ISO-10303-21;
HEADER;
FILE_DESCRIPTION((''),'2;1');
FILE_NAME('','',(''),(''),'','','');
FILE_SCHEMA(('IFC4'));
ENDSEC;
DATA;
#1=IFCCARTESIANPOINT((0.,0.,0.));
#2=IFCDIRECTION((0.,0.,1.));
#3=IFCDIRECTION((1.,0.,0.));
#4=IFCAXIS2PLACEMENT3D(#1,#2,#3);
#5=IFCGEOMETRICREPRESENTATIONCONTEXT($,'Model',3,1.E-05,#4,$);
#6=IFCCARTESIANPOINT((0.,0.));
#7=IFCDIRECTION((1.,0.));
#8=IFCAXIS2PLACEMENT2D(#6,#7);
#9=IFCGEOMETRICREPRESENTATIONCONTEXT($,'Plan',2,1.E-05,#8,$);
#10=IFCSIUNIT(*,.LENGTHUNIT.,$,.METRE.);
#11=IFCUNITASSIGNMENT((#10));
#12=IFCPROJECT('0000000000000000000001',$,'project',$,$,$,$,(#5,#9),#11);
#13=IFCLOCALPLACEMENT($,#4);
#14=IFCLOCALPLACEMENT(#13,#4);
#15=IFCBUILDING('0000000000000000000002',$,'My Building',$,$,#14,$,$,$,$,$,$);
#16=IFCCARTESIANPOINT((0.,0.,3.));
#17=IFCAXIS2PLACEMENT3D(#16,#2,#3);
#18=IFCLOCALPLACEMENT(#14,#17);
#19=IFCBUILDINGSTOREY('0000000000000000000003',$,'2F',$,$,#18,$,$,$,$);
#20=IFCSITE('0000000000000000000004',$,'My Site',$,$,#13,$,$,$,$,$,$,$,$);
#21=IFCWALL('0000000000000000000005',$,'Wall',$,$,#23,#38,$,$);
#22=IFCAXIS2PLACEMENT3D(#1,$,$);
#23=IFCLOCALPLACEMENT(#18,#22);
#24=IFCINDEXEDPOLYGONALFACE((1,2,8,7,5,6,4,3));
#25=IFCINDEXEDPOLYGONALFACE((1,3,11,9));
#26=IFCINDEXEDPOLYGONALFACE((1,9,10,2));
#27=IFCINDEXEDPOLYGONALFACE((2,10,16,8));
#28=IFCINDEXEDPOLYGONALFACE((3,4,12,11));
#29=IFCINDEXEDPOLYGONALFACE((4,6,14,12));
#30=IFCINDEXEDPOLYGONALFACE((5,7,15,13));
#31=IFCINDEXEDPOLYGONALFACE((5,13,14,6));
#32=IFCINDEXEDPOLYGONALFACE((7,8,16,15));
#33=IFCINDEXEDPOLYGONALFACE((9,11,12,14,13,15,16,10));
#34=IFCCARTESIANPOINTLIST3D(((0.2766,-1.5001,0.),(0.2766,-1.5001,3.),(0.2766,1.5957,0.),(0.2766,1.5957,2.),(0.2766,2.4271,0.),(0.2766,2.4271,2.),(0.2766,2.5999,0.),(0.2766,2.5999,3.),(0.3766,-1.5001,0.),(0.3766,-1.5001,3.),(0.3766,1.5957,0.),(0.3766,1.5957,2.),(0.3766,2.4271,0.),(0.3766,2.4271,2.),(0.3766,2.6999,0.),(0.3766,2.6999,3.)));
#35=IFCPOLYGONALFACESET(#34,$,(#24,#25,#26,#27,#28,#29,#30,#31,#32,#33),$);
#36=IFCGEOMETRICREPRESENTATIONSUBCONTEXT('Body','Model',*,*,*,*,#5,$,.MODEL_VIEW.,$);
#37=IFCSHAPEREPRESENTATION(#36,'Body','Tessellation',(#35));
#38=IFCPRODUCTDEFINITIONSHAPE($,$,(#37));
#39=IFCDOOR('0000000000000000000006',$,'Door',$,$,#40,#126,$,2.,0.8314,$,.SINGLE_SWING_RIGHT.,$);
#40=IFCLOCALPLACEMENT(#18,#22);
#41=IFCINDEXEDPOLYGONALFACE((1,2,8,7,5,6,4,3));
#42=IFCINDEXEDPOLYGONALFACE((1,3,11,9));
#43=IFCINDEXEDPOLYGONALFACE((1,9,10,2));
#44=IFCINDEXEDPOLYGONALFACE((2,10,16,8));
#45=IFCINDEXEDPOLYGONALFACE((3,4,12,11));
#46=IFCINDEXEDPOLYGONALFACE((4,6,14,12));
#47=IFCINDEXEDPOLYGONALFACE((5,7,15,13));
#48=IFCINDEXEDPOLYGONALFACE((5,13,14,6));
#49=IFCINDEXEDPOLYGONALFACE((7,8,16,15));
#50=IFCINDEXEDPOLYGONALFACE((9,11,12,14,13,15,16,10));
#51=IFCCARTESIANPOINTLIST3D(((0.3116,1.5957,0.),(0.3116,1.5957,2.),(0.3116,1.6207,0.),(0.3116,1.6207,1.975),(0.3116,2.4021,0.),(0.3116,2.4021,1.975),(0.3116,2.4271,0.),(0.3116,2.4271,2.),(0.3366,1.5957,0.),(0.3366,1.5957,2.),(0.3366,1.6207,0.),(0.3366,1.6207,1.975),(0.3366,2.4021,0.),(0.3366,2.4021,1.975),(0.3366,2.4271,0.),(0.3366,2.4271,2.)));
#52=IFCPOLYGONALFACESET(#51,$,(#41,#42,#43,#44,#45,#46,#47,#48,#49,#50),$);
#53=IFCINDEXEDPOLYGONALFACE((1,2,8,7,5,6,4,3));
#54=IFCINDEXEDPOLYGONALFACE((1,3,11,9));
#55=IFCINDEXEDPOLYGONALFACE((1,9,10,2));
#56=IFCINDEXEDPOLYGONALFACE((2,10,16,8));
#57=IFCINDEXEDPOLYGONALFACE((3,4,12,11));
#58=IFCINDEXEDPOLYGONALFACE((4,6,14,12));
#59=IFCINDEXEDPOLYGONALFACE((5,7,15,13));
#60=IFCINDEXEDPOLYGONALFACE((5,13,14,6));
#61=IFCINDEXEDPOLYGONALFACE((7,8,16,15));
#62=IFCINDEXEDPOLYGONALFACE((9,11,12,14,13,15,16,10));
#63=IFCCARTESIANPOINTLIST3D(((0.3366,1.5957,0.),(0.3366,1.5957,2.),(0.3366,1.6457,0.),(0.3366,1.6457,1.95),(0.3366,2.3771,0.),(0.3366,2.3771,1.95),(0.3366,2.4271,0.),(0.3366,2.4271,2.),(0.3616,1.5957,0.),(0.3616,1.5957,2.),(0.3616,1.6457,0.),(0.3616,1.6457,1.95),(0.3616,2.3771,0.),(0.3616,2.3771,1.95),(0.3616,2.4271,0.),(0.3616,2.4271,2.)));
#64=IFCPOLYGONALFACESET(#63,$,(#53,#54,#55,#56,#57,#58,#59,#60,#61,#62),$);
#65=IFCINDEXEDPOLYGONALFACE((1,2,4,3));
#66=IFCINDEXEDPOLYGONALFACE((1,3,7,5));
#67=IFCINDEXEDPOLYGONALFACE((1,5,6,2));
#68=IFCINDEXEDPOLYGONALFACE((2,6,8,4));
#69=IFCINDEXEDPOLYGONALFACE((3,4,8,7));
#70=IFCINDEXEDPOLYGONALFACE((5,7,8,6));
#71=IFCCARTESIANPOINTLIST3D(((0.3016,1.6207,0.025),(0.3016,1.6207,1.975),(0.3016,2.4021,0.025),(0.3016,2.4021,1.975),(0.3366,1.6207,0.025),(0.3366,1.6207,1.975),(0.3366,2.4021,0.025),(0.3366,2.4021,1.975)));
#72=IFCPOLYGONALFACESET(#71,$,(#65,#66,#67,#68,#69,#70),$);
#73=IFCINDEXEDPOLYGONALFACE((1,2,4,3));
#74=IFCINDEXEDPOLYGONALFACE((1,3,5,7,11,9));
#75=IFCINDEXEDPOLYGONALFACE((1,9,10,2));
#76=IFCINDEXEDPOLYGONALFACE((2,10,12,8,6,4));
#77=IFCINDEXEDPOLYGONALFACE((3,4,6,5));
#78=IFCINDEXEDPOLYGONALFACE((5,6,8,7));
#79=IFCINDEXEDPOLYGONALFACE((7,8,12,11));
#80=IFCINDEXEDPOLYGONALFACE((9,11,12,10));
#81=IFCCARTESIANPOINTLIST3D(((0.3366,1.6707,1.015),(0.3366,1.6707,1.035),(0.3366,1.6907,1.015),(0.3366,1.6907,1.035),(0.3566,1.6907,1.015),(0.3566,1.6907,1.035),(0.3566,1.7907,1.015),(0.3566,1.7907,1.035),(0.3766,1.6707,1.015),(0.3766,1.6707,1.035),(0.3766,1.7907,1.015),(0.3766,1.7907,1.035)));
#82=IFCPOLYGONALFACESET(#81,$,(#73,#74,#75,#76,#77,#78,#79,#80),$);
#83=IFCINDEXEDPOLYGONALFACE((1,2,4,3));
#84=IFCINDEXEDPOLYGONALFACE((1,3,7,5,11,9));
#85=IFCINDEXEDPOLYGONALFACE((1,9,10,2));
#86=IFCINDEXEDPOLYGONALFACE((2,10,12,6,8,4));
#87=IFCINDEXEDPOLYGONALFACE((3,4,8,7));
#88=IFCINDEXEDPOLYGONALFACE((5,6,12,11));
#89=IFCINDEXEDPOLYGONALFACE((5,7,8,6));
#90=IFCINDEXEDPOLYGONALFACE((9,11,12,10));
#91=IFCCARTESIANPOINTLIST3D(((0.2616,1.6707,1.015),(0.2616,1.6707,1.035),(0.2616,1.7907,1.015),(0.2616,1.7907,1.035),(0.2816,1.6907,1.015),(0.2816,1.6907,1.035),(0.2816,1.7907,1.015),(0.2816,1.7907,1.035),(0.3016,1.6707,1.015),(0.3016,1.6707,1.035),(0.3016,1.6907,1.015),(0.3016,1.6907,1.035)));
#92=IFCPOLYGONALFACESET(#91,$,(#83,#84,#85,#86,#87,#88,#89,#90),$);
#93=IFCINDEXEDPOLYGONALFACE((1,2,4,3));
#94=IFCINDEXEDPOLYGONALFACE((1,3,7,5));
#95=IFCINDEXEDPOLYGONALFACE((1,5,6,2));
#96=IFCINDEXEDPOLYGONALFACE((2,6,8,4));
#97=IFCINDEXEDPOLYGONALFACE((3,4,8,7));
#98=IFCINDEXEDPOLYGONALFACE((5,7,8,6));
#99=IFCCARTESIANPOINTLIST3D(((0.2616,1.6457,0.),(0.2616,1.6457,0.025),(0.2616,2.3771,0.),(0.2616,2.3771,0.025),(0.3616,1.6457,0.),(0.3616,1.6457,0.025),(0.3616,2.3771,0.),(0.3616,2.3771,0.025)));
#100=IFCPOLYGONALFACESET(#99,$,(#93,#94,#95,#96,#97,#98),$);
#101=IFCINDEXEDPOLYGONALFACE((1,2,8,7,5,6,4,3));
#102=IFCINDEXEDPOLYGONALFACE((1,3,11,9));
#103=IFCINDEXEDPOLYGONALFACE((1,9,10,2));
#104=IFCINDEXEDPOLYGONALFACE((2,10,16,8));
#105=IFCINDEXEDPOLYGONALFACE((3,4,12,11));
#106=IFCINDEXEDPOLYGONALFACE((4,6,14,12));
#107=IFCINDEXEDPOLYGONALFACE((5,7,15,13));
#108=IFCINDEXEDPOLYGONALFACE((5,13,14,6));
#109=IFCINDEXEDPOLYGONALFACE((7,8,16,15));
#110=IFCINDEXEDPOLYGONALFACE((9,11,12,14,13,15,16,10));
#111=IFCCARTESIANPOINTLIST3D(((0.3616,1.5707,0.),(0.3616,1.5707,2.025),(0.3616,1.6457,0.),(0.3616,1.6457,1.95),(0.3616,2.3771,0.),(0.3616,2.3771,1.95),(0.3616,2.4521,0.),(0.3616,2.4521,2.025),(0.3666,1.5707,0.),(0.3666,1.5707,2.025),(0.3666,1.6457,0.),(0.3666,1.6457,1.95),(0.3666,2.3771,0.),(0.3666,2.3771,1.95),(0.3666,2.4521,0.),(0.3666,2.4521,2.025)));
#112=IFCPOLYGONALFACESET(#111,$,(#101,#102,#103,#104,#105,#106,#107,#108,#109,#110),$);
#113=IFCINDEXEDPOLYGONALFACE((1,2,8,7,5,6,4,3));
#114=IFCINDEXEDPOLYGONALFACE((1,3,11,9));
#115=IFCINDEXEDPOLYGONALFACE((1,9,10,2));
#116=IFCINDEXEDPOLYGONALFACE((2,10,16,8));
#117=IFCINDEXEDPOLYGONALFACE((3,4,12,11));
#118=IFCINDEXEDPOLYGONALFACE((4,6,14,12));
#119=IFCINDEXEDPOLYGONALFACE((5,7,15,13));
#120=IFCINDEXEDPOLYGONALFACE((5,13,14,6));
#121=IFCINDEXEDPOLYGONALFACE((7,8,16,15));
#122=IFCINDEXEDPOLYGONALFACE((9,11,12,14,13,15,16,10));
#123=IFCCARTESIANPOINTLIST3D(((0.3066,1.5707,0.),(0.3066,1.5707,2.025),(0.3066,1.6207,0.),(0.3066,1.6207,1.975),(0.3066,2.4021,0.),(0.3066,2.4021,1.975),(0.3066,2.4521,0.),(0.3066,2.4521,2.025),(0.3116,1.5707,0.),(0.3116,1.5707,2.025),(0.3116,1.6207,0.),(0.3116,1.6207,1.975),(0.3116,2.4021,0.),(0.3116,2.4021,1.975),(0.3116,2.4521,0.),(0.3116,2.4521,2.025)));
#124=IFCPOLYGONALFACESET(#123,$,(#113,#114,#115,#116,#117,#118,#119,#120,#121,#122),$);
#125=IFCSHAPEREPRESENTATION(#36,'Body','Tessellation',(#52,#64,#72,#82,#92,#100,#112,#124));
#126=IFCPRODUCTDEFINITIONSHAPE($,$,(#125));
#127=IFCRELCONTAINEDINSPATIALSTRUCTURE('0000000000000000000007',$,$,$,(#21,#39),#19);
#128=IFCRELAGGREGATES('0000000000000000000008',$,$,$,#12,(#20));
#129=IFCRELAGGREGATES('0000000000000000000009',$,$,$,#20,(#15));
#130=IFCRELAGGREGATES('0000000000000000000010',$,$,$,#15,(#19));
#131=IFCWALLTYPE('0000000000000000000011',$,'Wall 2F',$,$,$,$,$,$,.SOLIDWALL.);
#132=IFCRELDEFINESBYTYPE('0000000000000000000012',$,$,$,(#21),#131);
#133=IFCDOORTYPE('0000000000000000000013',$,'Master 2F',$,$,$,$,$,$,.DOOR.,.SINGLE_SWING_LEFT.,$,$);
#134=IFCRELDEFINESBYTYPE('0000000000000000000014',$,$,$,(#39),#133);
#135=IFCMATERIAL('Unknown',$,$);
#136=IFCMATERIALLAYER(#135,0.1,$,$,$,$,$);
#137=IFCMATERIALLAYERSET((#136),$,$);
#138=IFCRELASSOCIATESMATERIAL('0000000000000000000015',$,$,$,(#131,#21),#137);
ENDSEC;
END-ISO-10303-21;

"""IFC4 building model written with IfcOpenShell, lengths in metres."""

from ifc_helpers import new_model, entity, si_unit, frame, origin_with_axes, origin_2d_with_axis, place, context, subcontext, project, spatial, line, indexed_curve, outline, extrude, shape, source, transform, mapped, material, layer, layer_set, layer_usage, type_object, type_shapes, element, fill, save


model = new_model("IFC4")

# Units and contexts
model_context = context("Model", 3, precision=1e-05, world=origin_with_axes())
plan_context = context("Plan", 2, precision=1e-05, world=origin_2d_with_axis())
body_context_1 = subcontext(model_context, "Body", "Model", "MODEL_VIEW")
body_context_2 = subcontext(plan_context, "Body", "Plan", "PLAN_VIEW")
ifc_project = project(units=[si_unit("LENGTHUNIT", "METRE")], contexts=[model_context, plan_context])

# Site, building, storey
site_placement = place(None, origin_with_axes())
site = spatial("IfcSite", under=ifc_project, at=site_placement, Name="My Site")
building_placement = place(site_placement, origin_with_axes())
building = spatial("IfcBuilding", under=site, at=building_placement, Name="My Building")
storey_placement = place(building_placement, frame((0.0, 0.0, 3.0), z_axis=(0.0, 0.0, 1.0), x_axis=(1.0, 0.0, 0.0)))
storey = spatial("IfcBuildingStorey", under=building, at=storey_placement, Name="2F")

# Shared definitions
ifc_material = material(Name="Unknown")

# Shared definitions
ifc_layer = layer(ifc_material, 0.1)
ifc_layer_set = layer_set([ifc_layer])
wall_type = type_object("IfcWallType", Name="Wall 2F", PredefinedType="SOLIDWALL", material=ifc_layer_set)

# Wall, opening, door
ifc_layer_usage_1 = layer_usage(ifc_layer_set, "AXIS2", "POSITIVE", 0.0)
wall_1_placement = place(storey_placement, frame((0.3766, -1.6001, 0.0), z_axis=(0.0, 0.0, 1.0), x_axis=(0.0, 1.0, 0.0)))
wall_1 = element("IfcWall", 1, at=wall_1_placement, inside=storey, type_object=wall_type, material=ifc_layer_usage_1, Name="Wall", context=body_context_1, shape_type="SweptSolid", body=[
    extrude(outline(indexed_curve([(0.1, 0.0), (0.1, 0.1), (4.2, 0.1), (4.3, 0.0)], segments=[line(1, 2, 3, 4, 1)])), origin_with_axes(), (0.0, 0.0, 1.0), 3.0),
])
shared_shape_1 = source(origin_with_axes(), body_context_1, "Body", "SweptSolid", [
    extrude(outline(indexed_curve([(0.0, 0.0), (0.8314, 0.0), (0.8314, 2.0), (0.0, 2.0)], segments=[line(1, 2, 3, 4, 1)])), frame((0.0, -0.6, 0.0), z_axis=(0.0, -1.0, 0.0), x_axis=(1.0, 0.0, 0.0)), (0.0, 0.0, -1.0), 1.2),
])
opening_1_placement = place(wall_1_placement, frame((3.1958, 0.015, 0.0), z_axis=(0.0, 0.0, 1.0), x_axis=(1.0, 0.0, 0.0)))
opening_1 = element("IfcOpeningElement", 2, at=opening_1_placement, cuts=wall_1, PredefinedType="OPENING", context=body_context_1, shape_type="MappedRepresentation", body=[
    mapped(shared_shape_1, transform((0.0, 0.0, 0.0), x_axis=(1.0, 0.0, 0.0), y_axis=(0.0, 1.0, 0.0), z_axis=(0.0, 0.0, 1.0), scale=1.0)),
])
door_type_1 = type_object("IfcDoorType", Name="Master 2F", OperationType="SINGLE_SWING_LEFT", PredefinedType="DOOR")
shared_shape_2 = source(origin_with_axes(), body_context_1, "Body", "SweptSolid", [
    extrude(outline(indexed_curve([(0.0, 0.0), (0.0, 2.0), (0.8314, 2.0), (0.8314, 0.0), (0.8064, 0.0), (0.8064, 1.975), (0.025, 1.975), (0.025, 0.0)], segments=[line(1, 2, 3, 4, 5, 6, 7, 8, 1)])), frame((0.0, 0.025, 0.0), z_axis=(0.0, -1.0, 0.0), x_axis=(1.0, 0.0, 0.0)), (0.0, 0.0, -1.0), 0.025),
    extrude(outline(indexed_curve([(0.0, 0.0), (0.0, 2.0), (0.8314, 2.0), (0.8314, 0.0), (0.7814, 0.0), (0.7814, 1.95), (0.05, 1.95), (0.05, 0.0)], segments=[line(1, 2, 3, 4, 5, 6, 7, 8, 1)])), frame((0.0, 0.0, 0.0), z_axis=(0.0, -1.0, 0.0), x_axis=(1.0, 0.0, 0.0)), (0.0, 0.0, -1.0), 0.025),
    extrude(outline(indexed_curve([(0.0, 0.0), (0.7814, 0.0), (0.7814, 0.035), (0.0, 0.035)], segments=[line(1, 2, 3, 4, 1)])), frame((0.025, 0.025, 0.025), z_axis=(0.0, 0.0, 1.0), x_axis=(1.0, 0.0, 0.0)), (0.0, 0.0, 1.0), 1.95),
    extrude(outline(indexed_curve([(0.0, 0.0), (0.0, -0.04), (0.12, -0.04), (0.12, -0.02), (0.02, -0.02), (0.02, 0.0)], segments=[line(1, 2, 3, 4, 5, 6, 1)])), frame((0.075, 0.025, 1.015), z_axis=(0.0, 0.0, 1.0), x_axis=(1.0, 0.0, 0.0)), (0.0, 0.0, 1.0), 0.02),
    extrude(outline(indexed_curve([(0.0, 0.0), (0.0, 0.04), (0.12, 0.04), (0.12, 0.02), (0.02, 0.02), (0.02, 0.0)], segments=[line(1, 2, 3, 4, 5, 6, 1)])), frame((0.075, 0.06, 1.015), z_axis=(0.0, 0.0, 1.0), x_axis=(1.0, 0.0, 0.0)), (0.0, 0.0, 1.0), 0.02),
    extrude(outline(indexed_curve([(0.0, 0.0), (0.7314, 0.0), (0.7314, 0.1), (0.0, 0.1)], segments=[line(1, 2, 3, 4, 1)])), frame((0.05, 0.0, 0.0), z_axis=(0.0, 0.0, 1.0), x_axis=(1.0, 0.0, 0.0)), (0.0, 0.0, 1.0), 0.025),
    extrude(outline(indexed_curve([(0.0, 0.0), (0.0, 2.025), (0.8814, 2.025), (0.8814, 0.0), (0.8064, 0.0), (0.8064, 1.95), (0.075, 1.95), (0.075, 0.0)], segments=[line(1, 2, 3, 4, 5, 6, 7, 8, 1)])), frame((-0.025, -0.005, 0.0), z_axis=(0.0, -1.0, 0.0), x_axis=(1.0, 0.0, 0.0)), (0.0, 0.0, -1.0), 0.005),
    extrude(outline(indexed_curve([(0.0, 0.0), (0.0, 2.025), (0.8814, 2.025), (0.8814, 0.0), (0.8314, 0.0), (0.8314, 1.975), (0.05, 1.975), (0.05, 0.0)], segments=[line(1, 2, 3, 4, 5, 6, 7, 8, 1)])), frame((-0.025, 0.05, 0.0), z_axis=(0.0, -1.0, 0.0), x_axis=(1.0, 0.0, 0.0)), (0.0, 0.0, -1.0), 0.005),
])
shared_shape_3 = source(origin_with_axes(), body_context_2, "Body", "Curve2D", [
    entity("IfcIndexedPolyCurve", entity("IfcCartesianPointList2D", [[0.0, 0.0], [0.0, 0.05], [0.025, 0.05], [0.025, 0.025], [0.05, 0.025], [0.05, 0.0]]), [entity("IfcLineIndex", [1, 2, 3, 4, 5, 6, 1])]),
    entity("IfcIndexedPolyCurve", entity("IfcCartesianPointList2D", [[0.8314, 0.0], [0.8314, 0.05], [0.8064, 0.05], [0.8064, 0.025], [0.7814, 0.025], [0.7814, 0.0]]), [entity("IfcLineIndex", [1, 2, 3, 4, 5, 6, 1])]),
    entity("IfcTrimmedCurve", entity("IfcEllipse", entity("IfcAxis2Placement2D", entity("IfcCartesianPoint", [0.7714, 0.05]), entity("IfcDirection", [1.0, 0.0])), 0.7464, 0.7814), [entity("IfcCartesianPoint", [0.7714, 0.8314])], [entity("IfcCartesianPoint", [0.025, 0.05])], True, "CARTESIAN"),
    entity("IfcIndexedPolyCurve", entity("IfcCartesianPointList2D", [[0.8064, 0.05], [0.7714, 0.05], [0.7714, 0.8314], [0.8064, 0.8314]]), [entity("IfcLineIndex", [1, 2, 3, 4, 1])]),
])
type_shapes(door_type_1, [shared_shape_2, shared_shape_3])
door_1_placement = place(opening_1_placement, frame((0.0, 0.0, 0.0), z_axis=(0.0, 0.0, 1.0), x_axis=(1.0, 0.0, 0.0)))
door_1 = element("IfcDoor", 3, at=door_1_placement, inside=storey, type_object=door_type_1, Name="Door", OperationType="SINGLE_SWING_RIGHT", OverallHeight=2.0, OverallWidth=0.8314, shapes=[
    shape(body_context_1, "Body", "MappedRepresentation", [mapped(shared_shape_2, transform((0.0, 0.0, 0.0), x_axis=(1.0, 0.0, 0.0), y_axis=(0.0, 1.0, 0.0), z_axis=(0.0, 0.0, 1.0), scale=1.0))]),
    shape(body_context_2, "Body", "MappedRepresentation", [mapped(shared_shape_3, transform((0.0, 0.0, 0.0), x_axis=(1.0, 0.0, 0.0), y_axis=(0.0, 1.0, 0.0), z_axis=(0.0, 0.0, 1.0), scale=1.0))]),
])
fill(opening_1, door_1)

save(model, "model.ifc")
